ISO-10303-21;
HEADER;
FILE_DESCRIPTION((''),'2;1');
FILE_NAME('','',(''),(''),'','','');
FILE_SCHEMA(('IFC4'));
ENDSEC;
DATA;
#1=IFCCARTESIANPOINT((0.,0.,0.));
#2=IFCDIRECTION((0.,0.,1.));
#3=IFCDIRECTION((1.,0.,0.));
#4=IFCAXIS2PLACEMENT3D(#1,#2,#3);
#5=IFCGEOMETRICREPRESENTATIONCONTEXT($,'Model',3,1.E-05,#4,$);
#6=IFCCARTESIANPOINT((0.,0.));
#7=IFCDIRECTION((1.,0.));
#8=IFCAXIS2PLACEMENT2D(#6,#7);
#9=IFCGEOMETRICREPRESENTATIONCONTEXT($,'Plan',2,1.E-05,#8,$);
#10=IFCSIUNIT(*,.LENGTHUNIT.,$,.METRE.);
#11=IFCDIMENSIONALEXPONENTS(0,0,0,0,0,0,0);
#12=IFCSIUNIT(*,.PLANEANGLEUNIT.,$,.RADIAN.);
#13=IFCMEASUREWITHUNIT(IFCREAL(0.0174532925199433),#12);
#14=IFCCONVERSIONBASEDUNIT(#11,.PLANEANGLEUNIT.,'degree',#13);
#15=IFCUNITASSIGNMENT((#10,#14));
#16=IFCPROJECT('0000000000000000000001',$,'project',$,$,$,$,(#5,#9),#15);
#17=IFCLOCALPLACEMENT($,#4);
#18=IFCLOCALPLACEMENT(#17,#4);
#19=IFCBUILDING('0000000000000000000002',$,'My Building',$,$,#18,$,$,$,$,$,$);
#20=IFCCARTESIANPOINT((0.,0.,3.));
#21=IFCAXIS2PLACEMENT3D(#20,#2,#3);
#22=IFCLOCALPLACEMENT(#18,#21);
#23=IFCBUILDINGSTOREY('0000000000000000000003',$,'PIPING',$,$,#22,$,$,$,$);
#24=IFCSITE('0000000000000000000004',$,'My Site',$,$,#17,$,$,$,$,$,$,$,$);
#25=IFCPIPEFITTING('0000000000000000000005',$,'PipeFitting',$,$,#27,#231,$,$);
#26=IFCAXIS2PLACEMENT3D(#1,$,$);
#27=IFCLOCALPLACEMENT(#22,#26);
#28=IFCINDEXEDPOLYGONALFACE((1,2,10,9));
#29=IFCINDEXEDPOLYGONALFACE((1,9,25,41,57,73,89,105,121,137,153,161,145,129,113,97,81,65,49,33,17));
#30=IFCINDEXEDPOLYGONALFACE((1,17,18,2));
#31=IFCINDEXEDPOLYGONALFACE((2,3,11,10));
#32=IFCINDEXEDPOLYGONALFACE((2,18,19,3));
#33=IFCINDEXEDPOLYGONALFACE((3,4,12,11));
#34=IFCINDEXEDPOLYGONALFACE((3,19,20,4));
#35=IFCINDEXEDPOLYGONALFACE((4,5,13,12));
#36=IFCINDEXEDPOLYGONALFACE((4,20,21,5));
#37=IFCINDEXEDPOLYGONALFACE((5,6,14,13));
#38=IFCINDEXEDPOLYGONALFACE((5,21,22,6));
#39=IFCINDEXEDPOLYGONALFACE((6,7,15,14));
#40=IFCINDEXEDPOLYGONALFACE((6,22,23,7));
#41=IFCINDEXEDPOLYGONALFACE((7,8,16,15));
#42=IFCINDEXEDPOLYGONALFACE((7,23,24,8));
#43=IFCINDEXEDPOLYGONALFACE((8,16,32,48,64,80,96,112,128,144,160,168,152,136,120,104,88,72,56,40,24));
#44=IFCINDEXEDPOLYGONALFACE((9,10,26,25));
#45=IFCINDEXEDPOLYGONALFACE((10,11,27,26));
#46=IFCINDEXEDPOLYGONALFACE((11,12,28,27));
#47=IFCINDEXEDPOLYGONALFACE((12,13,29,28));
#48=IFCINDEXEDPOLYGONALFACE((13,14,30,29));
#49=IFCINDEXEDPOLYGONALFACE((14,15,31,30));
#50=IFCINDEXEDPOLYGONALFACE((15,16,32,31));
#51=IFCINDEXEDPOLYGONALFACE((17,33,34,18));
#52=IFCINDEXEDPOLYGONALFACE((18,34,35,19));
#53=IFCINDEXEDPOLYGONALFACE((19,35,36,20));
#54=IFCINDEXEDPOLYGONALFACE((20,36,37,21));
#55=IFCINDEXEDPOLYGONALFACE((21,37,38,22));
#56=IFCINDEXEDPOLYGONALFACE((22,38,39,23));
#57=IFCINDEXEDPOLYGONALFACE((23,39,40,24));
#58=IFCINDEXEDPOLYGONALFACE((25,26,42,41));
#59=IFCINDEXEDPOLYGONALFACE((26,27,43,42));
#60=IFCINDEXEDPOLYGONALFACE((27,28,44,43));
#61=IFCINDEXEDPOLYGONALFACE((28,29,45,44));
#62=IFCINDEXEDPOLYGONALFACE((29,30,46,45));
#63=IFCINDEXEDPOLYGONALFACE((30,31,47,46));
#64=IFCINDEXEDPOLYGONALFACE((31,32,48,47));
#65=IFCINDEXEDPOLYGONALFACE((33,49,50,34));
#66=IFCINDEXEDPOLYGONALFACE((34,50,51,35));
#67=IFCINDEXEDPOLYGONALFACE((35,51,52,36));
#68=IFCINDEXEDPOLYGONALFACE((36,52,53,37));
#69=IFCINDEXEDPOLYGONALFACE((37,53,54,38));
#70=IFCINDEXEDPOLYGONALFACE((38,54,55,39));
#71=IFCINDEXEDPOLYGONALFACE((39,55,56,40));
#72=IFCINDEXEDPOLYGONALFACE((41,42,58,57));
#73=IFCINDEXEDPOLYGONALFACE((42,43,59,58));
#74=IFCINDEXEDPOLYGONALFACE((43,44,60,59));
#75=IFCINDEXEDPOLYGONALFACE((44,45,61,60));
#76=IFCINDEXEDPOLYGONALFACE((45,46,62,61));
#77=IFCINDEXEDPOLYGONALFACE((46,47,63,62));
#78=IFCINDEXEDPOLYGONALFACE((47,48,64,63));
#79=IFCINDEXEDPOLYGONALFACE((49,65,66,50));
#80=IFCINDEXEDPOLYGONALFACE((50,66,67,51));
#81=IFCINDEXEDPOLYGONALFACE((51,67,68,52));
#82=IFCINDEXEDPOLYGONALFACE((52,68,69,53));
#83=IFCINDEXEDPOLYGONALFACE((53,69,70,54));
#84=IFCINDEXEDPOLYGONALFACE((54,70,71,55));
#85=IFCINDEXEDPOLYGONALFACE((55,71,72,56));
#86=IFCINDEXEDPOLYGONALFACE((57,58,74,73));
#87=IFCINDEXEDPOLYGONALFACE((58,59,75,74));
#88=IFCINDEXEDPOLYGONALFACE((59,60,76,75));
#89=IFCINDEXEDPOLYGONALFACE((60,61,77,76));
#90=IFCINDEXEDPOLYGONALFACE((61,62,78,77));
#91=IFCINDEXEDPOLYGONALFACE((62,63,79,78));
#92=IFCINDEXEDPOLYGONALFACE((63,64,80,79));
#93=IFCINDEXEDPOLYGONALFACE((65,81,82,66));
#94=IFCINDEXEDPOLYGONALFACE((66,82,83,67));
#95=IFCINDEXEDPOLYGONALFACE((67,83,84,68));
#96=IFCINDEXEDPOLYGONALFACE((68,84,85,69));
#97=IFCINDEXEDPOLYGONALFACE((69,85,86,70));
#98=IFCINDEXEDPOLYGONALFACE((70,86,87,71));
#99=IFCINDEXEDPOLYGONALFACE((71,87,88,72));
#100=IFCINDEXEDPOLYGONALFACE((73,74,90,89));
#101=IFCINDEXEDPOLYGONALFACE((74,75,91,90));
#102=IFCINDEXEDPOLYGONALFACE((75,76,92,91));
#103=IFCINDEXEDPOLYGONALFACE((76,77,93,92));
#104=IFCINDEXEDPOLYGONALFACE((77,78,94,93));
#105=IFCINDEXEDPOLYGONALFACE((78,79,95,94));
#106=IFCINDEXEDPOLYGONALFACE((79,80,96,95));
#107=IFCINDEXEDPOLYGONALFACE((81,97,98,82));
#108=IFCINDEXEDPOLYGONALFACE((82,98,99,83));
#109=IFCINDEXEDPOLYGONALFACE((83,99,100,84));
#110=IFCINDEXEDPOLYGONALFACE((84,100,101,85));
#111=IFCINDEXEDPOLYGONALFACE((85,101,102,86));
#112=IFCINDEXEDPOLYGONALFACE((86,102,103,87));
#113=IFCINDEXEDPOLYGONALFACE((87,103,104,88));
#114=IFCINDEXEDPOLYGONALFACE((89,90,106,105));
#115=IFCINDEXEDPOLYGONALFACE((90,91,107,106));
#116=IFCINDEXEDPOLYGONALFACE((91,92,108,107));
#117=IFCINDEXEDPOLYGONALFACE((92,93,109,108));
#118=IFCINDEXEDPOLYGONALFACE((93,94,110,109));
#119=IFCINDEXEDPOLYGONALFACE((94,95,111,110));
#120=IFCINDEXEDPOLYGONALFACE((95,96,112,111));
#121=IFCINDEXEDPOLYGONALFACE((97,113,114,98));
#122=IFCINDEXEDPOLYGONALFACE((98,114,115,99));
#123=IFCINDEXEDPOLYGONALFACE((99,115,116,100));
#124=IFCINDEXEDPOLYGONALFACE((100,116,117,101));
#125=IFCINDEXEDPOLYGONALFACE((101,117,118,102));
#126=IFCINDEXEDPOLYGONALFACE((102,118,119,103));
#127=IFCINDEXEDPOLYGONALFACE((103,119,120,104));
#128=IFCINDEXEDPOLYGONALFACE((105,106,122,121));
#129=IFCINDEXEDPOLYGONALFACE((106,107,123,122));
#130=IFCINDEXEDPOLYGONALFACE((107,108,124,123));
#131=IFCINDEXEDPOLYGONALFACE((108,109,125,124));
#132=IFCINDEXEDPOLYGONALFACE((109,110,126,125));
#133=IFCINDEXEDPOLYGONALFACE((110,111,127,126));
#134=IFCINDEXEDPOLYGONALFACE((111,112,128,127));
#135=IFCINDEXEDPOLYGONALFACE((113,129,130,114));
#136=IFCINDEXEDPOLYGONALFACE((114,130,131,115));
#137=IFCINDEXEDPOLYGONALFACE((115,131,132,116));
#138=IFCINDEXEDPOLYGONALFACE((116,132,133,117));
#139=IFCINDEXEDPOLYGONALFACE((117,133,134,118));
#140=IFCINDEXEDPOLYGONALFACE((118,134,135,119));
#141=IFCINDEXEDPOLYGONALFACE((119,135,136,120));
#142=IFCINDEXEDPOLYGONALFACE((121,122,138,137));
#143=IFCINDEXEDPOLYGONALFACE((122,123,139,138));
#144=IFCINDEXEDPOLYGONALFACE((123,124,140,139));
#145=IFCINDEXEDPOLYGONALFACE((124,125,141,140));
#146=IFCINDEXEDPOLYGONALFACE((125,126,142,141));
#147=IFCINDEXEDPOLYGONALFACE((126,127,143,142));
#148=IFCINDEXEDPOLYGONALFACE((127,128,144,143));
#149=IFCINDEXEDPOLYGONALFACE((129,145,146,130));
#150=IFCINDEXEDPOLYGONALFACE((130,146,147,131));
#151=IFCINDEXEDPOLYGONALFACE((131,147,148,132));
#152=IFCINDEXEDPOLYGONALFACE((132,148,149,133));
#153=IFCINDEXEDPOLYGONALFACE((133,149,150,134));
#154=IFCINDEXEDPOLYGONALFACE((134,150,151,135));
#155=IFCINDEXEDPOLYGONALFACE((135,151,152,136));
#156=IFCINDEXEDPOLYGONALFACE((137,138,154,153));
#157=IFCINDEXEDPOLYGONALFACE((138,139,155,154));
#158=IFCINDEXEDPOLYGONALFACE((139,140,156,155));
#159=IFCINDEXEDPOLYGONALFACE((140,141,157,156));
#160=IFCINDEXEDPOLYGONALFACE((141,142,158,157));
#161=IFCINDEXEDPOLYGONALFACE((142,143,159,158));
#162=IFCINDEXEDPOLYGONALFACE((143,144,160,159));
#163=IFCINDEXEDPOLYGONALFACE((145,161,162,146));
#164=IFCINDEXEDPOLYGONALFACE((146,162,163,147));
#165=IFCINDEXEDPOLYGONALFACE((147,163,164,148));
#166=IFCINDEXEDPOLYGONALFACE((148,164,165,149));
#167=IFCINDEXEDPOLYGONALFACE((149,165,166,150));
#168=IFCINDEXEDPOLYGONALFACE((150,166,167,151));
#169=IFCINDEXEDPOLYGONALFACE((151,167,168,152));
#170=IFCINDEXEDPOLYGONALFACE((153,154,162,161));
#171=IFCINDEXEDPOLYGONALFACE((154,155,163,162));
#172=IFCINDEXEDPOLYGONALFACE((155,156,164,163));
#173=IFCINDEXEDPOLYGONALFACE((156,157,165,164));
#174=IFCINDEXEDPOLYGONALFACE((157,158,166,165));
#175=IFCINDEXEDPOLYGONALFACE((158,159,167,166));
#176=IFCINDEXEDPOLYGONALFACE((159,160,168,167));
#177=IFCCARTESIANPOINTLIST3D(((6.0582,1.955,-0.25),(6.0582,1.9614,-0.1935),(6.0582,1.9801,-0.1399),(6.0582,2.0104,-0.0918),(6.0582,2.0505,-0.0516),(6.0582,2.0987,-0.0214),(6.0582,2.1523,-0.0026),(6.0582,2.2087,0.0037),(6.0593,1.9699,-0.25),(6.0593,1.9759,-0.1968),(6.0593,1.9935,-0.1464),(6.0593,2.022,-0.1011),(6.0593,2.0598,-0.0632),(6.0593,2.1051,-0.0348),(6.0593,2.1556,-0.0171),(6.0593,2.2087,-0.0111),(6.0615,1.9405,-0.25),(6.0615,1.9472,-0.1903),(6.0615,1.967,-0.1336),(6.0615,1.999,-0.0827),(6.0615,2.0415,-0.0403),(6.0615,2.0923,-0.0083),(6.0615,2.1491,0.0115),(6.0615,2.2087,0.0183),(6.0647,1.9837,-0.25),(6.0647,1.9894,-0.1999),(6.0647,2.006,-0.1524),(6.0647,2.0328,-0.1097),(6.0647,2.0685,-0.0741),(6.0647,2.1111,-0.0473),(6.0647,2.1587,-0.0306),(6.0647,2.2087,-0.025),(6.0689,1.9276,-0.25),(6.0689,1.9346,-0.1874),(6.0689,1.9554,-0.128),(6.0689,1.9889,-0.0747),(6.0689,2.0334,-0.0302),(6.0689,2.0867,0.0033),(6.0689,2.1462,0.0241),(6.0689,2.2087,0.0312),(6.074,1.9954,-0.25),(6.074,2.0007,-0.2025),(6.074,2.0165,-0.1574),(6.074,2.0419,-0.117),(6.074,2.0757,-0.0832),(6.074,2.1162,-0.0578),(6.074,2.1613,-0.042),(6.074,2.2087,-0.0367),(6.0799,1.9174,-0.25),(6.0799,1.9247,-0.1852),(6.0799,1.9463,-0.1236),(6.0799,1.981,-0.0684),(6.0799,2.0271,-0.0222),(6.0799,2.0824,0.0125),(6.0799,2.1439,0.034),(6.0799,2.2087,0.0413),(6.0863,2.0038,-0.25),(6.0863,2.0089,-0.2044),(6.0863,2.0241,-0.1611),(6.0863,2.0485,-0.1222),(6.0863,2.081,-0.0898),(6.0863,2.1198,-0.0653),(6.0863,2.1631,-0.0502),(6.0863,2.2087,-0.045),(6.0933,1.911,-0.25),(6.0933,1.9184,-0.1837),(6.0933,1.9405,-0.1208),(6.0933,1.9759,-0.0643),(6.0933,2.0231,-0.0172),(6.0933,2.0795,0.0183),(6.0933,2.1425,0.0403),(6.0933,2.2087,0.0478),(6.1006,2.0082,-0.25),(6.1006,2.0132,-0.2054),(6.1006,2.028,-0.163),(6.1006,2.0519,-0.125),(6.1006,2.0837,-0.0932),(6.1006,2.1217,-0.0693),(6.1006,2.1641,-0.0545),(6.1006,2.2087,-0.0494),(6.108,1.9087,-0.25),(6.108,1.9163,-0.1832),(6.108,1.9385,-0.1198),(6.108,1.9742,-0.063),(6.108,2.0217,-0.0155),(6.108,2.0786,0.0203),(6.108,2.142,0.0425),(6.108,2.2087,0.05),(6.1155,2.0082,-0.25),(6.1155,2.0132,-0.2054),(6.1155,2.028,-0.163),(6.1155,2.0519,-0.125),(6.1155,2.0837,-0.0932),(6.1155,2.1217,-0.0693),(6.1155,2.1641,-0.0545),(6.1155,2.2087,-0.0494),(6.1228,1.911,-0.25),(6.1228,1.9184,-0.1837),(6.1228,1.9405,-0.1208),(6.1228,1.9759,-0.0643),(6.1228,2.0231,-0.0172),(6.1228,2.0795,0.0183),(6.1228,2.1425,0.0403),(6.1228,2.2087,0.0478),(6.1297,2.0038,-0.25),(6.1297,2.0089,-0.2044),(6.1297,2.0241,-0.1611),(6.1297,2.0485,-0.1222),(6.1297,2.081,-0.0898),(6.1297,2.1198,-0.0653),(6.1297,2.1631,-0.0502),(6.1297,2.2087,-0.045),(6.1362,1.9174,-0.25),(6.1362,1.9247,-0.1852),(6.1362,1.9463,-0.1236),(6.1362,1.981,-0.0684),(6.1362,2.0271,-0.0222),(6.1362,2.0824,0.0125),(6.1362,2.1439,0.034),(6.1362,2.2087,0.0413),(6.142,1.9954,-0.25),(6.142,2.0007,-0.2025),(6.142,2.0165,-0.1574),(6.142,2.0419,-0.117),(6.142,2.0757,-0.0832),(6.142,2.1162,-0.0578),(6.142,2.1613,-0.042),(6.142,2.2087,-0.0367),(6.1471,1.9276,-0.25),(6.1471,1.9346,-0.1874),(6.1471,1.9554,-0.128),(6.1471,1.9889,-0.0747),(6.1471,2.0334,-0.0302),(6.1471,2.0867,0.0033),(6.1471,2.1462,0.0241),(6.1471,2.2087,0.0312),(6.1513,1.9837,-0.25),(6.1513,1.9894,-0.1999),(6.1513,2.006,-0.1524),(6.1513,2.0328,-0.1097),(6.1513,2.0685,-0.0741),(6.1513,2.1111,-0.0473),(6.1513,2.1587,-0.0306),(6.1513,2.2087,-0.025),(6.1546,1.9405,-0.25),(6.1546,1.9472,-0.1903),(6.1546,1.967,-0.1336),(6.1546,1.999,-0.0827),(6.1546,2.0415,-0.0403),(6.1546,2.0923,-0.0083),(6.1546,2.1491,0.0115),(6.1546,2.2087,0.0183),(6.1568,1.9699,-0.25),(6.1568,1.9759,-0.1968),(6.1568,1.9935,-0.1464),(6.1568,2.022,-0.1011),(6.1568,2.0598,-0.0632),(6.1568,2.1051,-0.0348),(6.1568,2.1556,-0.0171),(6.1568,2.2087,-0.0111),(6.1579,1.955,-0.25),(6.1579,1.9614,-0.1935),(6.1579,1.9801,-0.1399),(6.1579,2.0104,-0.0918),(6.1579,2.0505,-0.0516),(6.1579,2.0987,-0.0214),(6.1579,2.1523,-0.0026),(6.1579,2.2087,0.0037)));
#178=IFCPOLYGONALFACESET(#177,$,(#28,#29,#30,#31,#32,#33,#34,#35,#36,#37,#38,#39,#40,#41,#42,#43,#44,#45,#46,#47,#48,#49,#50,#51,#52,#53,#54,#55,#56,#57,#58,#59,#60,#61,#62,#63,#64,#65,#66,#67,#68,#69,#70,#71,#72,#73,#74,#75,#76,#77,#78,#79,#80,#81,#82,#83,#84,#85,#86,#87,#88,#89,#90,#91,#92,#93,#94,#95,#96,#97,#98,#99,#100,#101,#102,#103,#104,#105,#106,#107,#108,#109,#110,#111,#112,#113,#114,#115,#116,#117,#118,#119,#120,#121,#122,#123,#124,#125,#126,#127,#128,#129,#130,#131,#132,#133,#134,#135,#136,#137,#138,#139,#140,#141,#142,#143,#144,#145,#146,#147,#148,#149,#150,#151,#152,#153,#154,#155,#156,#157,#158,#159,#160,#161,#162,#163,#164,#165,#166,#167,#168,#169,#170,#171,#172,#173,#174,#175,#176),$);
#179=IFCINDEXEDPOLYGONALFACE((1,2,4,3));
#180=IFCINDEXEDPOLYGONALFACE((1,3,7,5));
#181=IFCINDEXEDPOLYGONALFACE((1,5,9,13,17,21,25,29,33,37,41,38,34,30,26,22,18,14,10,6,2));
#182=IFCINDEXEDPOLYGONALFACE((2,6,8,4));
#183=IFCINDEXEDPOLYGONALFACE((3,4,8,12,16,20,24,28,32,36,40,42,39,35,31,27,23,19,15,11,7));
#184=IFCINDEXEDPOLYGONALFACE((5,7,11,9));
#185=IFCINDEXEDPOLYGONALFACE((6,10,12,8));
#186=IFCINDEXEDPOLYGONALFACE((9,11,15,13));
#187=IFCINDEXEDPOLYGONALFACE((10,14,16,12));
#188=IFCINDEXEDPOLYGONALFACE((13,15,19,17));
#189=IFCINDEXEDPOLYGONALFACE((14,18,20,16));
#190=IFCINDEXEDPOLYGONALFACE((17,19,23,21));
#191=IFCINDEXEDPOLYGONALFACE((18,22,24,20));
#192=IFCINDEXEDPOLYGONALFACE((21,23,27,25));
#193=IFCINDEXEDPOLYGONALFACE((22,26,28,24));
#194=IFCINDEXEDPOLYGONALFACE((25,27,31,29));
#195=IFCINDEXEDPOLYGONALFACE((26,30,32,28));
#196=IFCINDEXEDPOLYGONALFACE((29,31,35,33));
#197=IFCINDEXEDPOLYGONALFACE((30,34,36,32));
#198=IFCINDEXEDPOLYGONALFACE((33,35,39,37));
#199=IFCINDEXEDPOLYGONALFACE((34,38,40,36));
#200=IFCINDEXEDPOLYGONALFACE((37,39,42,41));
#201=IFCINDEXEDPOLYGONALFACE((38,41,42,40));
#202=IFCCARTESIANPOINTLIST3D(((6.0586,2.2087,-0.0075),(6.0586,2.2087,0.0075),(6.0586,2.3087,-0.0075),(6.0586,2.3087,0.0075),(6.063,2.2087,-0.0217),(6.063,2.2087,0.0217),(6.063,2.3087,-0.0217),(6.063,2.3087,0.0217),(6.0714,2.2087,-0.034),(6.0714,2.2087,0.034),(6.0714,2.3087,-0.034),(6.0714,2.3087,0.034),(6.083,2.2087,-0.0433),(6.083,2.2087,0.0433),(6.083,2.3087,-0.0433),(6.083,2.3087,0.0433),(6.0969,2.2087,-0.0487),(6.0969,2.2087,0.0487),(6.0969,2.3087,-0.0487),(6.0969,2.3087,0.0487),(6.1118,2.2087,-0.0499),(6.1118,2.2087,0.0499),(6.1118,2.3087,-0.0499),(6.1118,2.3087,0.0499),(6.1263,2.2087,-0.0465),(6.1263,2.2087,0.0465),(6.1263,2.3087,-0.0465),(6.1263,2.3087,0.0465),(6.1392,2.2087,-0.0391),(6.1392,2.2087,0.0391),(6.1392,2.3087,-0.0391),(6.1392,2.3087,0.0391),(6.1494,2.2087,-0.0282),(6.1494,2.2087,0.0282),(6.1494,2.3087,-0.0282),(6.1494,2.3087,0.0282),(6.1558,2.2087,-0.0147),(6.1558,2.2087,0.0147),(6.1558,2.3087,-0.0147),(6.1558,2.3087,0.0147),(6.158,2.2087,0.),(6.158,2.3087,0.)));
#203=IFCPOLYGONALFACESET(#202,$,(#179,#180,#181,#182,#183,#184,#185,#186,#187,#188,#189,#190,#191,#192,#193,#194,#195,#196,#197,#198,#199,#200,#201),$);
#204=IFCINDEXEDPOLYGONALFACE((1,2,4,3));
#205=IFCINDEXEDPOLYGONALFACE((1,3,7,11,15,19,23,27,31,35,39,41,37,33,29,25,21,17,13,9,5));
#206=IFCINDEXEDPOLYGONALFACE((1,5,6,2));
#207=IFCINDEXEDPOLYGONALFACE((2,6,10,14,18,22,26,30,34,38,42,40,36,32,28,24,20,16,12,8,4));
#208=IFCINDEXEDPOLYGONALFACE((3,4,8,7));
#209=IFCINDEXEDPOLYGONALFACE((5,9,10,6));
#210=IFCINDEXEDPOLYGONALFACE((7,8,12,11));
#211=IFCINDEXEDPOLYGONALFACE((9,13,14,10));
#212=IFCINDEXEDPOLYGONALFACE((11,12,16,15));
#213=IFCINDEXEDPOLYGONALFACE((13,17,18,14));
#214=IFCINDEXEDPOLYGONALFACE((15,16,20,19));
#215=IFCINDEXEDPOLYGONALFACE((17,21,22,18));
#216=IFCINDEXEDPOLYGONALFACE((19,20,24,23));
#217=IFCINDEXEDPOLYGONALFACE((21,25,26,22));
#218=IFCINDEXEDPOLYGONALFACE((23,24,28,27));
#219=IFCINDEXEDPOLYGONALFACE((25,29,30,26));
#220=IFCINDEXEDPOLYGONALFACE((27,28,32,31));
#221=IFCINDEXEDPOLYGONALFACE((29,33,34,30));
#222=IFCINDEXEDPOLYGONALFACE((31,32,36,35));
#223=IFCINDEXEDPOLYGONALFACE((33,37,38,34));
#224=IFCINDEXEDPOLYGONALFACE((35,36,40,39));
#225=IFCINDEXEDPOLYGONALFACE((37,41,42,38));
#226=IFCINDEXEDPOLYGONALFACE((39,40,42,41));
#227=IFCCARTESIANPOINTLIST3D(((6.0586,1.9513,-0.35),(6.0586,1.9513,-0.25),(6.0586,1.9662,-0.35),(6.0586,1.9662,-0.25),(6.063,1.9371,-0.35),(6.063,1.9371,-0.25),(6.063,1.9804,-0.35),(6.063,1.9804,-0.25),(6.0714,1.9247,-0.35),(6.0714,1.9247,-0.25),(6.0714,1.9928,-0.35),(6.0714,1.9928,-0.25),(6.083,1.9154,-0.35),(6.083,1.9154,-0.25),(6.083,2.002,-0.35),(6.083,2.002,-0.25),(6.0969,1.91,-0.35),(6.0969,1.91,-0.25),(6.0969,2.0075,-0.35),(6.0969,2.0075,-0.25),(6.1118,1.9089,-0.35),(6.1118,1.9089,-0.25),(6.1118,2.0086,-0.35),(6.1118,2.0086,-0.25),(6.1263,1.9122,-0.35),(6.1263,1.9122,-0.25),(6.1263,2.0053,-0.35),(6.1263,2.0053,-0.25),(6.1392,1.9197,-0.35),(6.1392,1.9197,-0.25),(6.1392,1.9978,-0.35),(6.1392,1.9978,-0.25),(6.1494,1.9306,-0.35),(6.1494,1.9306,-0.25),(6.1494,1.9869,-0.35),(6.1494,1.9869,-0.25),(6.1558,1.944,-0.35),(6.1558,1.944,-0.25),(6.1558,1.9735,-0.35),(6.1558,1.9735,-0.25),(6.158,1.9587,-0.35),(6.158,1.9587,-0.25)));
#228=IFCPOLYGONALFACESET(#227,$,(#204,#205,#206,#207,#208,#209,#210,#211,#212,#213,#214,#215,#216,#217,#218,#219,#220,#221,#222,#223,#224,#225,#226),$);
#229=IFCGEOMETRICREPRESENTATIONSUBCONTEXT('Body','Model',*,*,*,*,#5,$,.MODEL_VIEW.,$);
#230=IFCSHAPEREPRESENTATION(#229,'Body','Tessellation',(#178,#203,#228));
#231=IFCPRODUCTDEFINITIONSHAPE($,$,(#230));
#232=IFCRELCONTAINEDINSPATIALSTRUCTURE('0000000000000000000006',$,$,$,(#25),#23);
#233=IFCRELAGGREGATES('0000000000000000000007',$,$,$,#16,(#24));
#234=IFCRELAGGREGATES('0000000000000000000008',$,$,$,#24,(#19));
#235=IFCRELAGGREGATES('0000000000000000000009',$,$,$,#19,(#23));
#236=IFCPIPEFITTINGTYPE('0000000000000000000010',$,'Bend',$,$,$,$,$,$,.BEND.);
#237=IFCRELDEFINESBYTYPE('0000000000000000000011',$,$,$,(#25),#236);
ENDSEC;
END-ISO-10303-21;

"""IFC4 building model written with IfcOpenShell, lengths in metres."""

from ifc_helpers import new_model, entity, si_unit, converted_unit, frame, origin_with_axes, origin_2d_with_axis, place, context, subcontext, project, spatial, line, indexed_curve, circle, outline, extrude, source, transform, mapped, type_object, type_shapes, element, save


model = new_model("IFC4")

# Units and contexts
model_context = context("Model", 3, precision=1e-05, world=origin_with_axes())
plan_context = context("Plan", 2, precision=1e-05, world=origin_2d_with_axis())
body_context = subcontext(model_context, "Body", "Model", "MODEL_VIEW")
ifc_project = project(units=[si_unit("LENGTHUNIT", "METRE"), converted_unit("PLANEANGLEUNIT", "degree", entity("IfcReal", 0.0174532925199433), si_unit("PLANEANGLEUNIT", "RADIAN"), dimensions=[0, 0, 0, 0, 0, 0, 0])], contexts=[model_context, plan_context])

# Site, building, storey
site_placement = place(None, origin_with_axes())
site = spatial("IfcSite", under=ifc_project, at=site_placement, Name="My Site")
building_placement = place(site_placement, origin_with_axes())
building = spatial("IfcBuilding", under=site, at=building_placement, Name="My Building")
storey_placement = place(building_placement, frame((0.0, 0.0, 3.0), z_axis=(0.0, 0.0, 1.0), x_axis=(1.0, 0.0, 0.0)))
storey = spatial("IfcBuildingStorey", under=building, at=storey_placement, Name="PIPING")

# Pipe fitting, opening
pipe_fitting_type = type_object("IfcPipeFittingType", Name="Bend", PredefinedType="BEND")
shared_shape = source(origin_with_axes(), body_context, "Body", "SolidModel", [
    entity("IfcSweptDiskSolid", entity("IfcIndexedPolyCurve", entity("IfcCartesianPointList3D", [[0.0, 0.0, 0.1], [0.0, -0.0732, 0.2768], [0.0, -0.25, 0.35]]), [entity("IfcArcIndex", [1, 2, 3])]), 0.05),
    extrude(circle(Radius=0.05), origin_with_axes(), (0.0, 0.0, 1.0), 0.1),
    extrude(circle(Radius=0.05), frame((0.0, -0.25, 0.35), z_axis=(0.0, -1.0, 0.0), x_axis=(1.0, 0.0, 0.0)), (0.0, 0.0, 1.0), 0.1),
])
type_shapes(pipe_fitting_type, [shared_shape])
pipe_fitting_1_placement = place(storey_placement, frame((6.108, 2.3087, 0.0), z_axis=(0.0, -1.0, 0.0), x_axis=(1.0, 0.0, 0.0)))
pipe_fitting_1 = element("IfcPipeFitting", 1, at=pipe_fitting_1_placement, inside=storey, type_object=pipe_fitting_type, Name="PipeFitting", context=body_context, shape_type="MappedRepresentation", body=[
    mapped(shared_shape, transform((0.0, 0.0, 0.0), x_axis=(1.0, 0.0, 0.0), y_axis=(0.0, 1.0, 0.0), z_axis=(0.0, 0.0, 1.0), scale=1.0)),
])
opening_1_placement = place(pipe_fitting_1_placement, frame((-6.108, -3.0, 2.3087), z_axis=(0.0, 1.0, 0.0), x_axis=(1.0, 0.0, 0.0)))
element("IfcOpeningElement", 2, at=opening_1_placement, cuts=pipe_fitting_1, PredefinedType="OPENING", context=body_context, shape_type="SweptSolid", body=[
    extrude(outline(indexed_curve([(0.0, 0.0), (0.5, 0.0), (0.5, 0.5), (0.0, 0.5)], segments=[line(1, 2, 3, 4, 1)])), origin_with_axes(), (0.0, 0.0, 1.0), 0.5),
])

save(model, "model.ifc")
